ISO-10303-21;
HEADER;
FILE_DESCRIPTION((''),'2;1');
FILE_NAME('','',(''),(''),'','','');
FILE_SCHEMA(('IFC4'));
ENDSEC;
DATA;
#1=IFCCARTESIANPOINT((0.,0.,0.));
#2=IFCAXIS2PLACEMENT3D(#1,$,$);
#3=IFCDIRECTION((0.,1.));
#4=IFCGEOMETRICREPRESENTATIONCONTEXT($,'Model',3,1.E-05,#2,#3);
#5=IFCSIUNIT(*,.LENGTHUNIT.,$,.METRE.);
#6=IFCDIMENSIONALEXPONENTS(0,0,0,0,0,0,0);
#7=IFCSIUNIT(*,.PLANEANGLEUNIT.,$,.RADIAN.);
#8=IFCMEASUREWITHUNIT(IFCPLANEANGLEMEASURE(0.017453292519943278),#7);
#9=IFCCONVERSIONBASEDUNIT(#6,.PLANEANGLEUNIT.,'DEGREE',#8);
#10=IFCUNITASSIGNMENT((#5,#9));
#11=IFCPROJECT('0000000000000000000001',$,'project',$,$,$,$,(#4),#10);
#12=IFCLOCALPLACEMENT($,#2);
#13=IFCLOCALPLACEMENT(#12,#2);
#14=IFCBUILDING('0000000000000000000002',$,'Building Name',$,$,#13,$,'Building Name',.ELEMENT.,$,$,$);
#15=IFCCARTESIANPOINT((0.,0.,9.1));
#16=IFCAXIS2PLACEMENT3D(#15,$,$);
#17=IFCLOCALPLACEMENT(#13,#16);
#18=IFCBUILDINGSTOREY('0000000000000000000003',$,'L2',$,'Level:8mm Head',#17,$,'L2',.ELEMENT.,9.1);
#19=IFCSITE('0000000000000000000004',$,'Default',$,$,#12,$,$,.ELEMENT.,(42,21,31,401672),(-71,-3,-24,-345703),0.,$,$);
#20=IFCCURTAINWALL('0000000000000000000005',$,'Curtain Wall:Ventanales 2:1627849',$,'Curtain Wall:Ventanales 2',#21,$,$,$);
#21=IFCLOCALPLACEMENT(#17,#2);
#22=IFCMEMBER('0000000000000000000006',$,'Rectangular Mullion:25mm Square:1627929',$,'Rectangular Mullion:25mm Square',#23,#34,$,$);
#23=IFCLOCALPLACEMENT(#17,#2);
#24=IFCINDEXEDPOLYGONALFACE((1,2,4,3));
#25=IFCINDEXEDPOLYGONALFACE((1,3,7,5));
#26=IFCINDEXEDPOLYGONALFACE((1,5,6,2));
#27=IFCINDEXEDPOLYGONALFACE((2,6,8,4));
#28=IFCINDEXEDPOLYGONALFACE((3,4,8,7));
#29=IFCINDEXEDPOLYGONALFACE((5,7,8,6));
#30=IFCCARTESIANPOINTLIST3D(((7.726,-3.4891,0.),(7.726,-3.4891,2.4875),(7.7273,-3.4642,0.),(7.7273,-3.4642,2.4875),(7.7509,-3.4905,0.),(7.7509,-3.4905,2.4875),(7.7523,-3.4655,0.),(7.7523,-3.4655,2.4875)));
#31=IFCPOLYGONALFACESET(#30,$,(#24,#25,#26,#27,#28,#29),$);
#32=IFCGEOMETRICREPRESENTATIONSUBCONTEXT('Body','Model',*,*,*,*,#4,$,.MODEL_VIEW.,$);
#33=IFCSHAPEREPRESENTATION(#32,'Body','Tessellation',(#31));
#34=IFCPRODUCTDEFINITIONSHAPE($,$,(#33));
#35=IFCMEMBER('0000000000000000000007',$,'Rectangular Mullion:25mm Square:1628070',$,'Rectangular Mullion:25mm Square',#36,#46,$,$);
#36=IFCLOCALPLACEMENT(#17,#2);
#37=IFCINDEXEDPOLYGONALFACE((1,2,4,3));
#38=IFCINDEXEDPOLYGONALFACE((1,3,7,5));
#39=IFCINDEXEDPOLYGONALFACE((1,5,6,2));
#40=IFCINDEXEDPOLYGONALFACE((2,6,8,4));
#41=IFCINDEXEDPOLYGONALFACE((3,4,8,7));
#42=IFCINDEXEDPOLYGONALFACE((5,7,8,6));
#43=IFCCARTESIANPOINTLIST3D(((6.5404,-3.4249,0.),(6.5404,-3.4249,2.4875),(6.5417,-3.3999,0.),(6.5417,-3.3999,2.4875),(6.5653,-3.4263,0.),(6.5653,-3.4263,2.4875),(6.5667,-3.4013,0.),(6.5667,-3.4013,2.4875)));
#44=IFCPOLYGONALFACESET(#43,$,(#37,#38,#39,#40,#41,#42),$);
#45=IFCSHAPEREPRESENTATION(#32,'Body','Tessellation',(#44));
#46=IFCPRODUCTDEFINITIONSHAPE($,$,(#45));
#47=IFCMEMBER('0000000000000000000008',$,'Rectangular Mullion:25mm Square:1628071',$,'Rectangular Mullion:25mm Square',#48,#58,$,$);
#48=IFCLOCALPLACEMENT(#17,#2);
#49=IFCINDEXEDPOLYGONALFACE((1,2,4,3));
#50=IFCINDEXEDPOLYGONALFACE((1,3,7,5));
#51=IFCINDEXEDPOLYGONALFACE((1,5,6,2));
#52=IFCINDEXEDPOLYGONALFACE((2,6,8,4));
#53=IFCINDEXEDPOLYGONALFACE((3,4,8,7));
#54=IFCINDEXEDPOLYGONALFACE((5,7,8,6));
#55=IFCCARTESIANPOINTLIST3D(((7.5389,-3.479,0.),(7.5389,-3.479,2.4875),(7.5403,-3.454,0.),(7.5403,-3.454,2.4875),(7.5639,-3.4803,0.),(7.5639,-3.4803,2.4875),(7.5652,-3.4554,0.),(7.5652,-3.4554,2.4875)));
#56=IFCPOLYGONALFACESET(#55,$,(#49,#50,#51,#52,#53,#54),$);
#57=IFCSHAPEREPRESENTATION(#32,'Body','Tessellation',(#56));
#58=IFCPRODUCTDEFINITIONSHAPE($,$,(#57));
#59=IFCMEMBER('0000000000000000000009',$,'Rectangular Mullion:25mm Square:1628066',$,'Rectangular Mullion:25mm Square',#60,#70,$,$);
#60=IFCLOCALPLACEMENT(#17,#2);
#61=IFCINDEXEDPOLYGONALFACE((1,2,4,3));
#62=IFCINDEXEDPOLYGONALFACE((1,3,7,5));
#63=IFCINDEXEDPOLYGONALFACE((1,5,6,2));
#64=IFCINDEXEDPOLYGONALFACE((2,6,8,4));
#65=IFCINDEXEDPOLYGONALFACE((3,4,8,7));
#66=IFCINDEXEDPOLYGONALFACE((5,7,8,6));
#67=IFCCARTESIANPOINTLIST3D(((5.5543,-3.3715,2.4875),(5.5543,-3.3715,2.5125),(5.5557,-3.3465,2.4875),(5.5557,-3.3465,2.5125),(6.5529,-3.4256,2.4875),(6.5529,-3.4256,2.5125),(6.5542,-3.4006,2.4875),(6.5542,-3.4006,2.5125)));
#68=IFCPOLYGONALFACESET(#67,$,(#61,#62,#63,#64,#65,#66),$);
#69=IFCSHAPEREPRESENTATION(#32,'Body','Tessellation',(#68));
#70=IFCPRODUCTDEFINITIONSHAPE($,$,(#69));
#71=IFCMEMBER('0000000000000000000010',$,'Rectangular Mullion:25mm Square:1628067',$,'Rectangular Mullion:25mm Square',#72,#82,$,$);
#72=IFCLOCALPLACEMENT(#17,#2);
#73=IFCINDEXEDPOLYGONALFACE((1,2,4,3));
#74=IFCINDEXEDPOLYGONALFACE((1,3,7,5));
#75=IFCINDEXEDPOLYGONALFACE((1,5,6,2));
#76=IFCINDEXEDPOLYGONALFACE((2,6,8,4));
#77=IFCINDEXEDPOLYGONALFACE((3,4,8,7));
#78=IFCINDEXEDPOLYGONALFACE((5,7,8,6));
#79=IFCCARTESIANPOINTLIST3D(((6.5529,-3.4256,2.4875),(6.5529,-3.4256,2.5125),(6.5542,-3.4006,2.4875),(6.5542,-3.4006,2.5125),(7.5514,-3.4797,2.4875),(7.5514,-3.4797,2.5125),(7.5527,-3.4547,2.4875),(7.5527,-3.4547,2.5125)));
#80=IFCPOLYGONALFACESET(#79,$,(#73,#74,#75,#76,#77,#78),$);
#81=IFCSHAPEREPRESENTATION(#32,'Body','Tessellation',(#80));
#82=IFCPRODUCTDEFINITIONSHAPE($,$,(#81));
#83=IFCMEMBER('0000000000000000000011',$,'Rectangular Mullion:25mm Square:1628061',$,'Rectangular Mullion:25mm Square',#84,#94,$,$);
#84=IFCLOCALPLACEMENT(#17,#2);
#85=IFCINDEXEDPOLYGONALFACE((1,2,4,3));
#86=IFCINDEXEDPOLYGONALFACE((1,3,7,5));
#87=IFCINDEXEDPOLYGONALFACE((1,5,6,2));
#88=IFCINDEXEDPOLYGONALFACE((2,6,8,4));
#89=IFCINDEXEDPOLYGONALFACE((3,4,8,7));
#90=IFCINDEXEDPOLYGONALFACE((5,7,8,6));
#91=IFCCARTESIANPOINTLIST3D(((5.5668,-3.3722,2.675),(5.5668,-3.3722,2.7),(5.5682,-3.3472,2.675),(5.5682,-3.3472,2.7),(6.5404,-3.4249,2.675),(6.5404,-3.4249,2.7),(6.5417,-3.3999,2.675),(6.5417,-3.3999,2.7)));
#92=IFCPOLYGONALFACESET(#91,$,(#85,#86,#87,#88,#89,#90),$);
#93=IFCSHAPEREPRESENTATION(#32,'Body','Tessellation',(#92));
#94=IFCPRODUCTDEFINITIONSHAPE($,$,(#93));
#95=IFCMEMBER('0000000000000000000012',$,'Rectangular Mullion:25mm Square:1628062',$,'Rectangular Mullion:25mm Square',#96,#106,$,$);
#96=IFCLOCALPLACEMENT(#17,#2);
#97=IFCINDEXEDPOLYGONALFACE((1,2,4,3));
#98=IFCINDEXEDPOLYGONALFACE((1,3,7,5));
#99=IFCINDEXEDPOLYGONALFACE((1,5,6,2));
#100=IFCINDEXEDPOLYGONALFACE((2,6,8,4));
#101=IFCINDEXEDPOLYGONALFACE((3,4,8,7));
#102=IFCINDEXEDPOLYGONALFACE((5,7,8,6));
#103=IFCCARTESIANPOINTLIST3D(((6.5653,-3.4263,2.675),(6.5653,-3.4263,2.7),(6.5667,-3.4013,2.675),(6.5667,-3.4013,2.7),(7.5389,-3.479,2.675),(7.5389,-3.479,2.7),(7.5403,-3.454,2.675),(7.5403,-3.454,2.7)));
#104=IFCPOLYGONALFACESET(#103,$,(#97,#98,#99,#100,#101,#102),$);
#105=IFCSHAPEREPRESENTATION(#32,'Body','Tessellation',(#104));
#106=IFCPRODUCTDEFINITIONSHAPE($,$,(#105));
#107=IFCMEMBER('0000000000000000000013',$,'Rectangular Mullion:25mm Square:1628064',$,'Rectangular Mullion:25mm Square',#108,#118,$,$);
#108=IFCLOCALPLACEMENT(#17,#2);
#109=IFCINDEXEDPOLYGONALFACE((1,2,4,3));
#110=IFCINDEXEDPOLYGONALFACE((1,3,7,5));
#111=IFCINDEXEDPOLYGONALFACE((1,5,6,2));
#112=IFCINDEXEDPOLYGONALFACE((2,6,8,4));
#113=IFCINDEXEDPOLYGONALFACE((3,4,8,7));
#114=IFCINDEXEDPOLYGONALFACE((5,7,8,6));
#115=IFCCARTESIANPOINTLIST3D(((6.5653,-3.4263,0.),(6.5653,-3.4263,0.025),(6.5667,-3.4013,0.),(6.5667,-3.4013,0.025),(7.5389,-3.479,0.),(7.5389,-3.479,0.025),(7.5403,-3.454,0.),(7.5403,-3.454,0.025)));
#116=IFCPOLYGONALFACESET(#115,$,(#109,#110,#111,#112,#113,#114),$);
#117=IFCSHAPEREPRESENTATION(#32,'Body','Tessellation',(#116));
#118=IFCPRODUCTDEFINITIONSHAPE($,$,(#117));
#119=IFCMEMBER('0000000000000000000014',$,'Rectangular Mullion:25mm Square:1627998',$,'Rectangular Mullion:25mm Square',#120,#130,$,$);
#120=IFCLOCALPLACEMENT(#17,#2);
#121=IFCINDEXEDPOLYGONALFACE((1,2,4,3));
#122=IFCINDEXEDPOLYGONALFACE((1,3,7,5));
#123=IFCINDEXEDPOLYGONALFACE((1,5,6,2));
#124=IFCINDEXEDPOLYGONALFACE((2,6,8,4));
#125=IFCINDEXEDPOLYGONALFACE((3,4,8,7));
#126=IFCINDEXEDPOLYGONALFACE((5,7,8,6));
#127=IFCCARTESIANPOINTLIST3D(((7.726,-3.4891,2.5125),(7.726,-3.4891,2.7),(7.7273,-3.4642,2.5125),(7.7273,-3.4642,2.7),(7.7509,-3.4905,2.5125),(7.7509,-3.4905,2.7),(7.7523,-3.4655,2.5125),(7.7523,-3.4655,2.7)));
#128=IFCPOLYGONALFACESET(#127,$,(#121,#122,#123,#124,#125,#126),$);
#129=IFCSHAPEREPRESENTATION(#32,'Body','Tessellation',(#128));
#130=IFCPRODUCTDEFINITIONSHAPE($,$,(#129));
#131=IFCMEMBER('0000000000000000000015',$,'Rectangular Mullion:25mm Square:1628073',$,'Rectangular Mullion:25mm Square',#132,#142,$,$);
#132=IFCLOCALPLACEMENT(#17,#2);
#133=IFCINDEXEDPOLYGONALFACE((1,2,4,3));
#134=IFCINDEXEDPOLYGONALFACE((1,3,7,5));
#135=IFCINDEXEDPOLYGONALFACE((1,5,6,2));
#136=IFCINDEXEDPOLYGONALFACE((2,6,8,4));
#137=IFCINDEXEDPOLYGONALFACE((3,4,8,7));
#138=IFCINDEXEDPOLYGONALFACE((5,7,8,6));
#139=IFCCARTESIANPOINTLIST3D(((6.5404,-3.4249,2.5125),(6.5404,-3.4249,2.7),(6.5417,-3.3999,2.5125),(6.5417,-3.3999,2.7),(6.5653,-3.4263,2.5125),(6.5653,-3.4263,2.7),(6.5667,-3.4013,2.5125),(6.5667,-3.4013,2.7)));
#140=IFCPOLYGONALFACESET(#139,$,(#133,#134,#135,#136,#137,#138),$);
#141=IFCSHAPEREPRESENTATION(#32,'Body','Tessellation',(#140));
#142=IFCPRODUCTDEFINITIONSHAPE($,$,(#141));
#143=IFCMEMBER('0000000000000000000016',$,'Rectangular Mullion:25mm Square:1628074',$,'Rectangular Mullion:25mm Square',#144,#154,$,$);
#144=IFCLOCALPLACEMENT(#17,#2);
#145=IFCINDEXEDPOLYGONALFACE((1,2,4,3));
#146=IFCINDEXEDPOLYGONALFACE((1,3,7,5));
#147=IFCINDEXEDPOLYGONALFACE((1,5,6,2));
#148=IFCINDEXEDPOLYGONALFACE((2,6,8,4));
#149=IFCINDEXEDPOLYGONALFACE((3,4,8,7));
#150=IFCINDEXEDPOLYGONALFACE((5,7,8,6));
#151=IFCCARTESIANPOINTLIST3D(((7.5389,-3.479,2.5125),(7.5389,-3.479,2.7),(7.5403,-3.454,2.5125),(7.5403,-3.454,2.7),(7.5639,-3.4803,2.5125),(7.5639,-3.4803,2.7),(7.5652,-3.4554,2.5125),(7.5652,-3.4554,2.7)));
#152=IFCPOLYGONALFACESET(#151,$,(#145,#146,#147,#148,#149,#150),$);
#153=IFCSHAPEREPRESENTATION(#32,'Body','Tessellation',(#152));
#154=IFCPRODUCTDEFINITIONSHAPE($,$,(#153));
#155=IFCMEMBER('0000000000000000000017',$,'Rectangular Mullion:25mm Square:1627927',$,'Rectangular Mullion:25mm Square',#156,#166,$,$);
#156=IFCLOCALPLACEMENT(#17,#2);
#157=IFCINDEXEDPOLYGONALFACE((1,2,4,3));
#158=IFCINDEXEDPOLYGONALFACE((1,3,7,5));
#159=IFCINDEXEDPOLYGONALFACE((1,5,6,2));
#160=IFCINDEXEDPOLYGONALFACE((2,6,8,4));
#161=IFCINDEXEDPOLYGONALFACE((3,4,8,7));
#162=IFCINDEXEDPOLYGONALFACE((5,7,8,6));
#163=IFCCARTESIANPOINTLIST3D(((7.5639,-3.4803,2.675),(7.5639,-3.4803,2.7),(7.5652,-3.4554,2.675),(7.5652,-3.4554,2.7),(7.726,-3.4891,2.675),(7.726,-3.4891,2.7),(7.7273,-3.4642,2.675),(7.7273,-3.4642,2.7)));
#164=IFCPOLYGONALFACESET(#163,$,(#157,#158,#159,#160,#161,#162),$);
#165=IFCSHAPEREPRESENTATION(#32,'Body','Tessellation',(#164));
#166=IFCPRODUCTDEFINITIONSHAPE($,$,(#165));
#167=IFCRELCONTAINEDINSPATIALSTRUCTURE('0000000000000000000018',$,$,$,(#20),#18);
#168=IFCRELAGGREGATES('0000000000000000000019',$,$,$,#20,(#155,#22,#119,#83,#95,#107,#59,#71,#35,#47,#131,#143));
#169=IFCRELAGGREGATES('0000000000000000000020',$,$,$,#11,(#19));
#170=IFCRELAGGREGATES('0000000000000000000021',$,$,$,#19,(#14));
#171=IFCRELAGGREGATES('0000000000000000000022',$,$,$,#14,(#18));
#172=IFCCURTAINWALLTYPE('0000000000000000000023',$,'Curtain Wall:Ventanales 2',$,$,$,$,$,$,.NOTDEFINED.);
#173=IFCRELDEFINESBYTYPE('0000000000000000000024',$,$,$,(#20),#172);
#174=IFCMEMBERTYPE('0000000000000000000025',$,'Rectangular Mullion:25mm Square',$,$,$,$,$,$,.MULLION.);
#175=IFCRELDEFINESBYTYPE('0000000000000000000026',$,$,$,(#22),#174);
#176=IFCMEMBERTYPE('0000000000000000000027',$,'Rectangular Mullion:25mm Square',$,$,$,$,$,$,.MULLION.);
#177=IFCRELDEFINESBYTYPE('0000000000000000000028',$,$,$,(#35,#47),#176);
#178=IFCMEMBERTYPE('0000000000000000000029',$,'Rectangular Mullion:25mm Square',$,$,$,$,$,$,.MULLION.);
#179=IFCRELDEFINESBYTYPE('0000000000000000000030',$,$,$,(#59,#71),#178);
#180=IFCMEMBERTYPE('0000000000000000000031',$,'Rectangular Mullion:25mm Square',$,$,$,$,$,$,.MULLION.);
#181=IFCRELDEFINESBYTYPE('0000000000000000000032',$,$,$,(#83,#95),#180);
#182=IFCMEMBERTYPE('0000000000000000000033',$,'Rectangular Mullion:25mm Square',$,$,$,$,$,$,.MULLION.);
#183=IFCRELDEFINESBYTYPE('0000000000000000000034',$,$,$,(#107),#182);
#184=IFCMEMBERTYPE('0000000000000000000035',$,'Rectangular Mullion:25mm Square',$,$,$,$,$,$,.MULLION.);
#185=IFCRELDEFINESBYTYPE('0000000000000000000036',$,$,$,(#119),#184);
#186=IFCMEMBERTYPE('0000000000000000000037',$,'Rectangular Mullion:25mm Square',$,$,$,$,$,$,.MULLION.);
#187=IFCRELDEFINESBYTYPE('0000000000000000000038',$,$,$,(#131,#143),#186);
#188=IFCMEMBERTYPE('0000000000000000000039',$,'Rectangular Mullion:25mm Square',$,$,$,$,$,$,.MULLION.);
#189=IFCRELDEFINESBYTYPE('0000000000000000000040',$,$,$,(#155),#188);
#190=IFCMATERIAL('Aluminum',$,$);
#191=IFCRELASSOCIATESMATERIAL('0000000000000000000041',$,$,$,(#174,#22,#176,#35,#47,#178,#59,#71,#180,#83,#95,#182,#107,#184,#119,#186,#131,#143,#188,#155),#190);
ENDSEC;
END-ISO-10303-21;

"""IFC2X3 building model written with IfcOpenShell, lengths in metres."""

from ifc_helpers import new_model, entity, si_unit, converted_unit, direction, frame, frame_2d, origin, origin_2d_with_axis, place, context, subcontext, project, spatial, rectangle, extrude, source, transform, mapped, material, type_object, type_shapes, element, aggregate, save


model = new_model("IFC2X3")

# Units and contexts
model_context = context("Model", 3, precision=1e-05, world=origin(), true_north=direction((0.0, 1.0)))
body_context = subcontext(model_context, "Body", "Model", "MODEL_VIEW")
ifc_project = project(units=[si_unit("LENGTHUNIT", "METRE"), converted_unit("PLANEANGLEUNIT", "DEGREE", entity("IfcPlaneAngleMeasure", 0.017453292519943278), si_unit("PLANEANGLEUNIT", "RADIAN"), dimensions=[0, 0, 0, 0, 0, 0, 0])], contexts=[model_context])

# Site, building, storey
site_placement = place(None, origin())
site = spatial("IfcSite", under=ifc_project, at=site_placement, Name="Default", CompositionType="ELEMENT", RefLatitude=(42, 21, 31, 401672), RefLongitude=(-71, -3, -24, -345703), RefElevation=0.0)
building_placement = place(site_placement, origin())
building = spatial("IfcBuilding", under=site, at=building_placement, Name="Building Name", LongName="Building Name", CompositionType="ELEMENT")
storey_placement = place(building_placement, frame((0.0, 0.0, 9.1)))
storey = spatial("IfcBuildingStorey", under=building, at=storey_placement, Name="L2", ObjectType="Level:8mm Head", LongName="L2", CompositionType="ELEMENT", Elevation=9.1)

# Curtain wall, members
curtain_wall_type = type_object("IfcCurtainWallType", Name="Curtain Wall:Ventanales 2", PredefinedType="NOTDEFINED")
curtain_wall_placement = place(storey_placement, frame((0.0, 0.0, -9.1)))
curtain_wall = element("IfcCurtainWall", 1, at=curtain_wall_placement, inside=storey, type_object=curtain_wall_type, Name="Curtain Wall:Ventanales 2:1627849", ObjectType="Curtain Wall:Ventanales 2")
ifc_material_1 = material(Name="Aluminum")
member_type_1 = type_object("IfcMemberType", Name="Rectangular Mullion:25mm Square", PredefinedType="MULLION", material=ifc_material_1)
shared_shape_1 = source(origin(), body_context, "Body", "SweptSolid", [
    extrude(rectangle(XDim=0.025, YDim=0.025, at=origin_2d_with_axis()), frame((-0.0125, 0.0, -2.4875), z_axis=(0.0, 0.0, 1.0), x_axis=(-1.0, 0.0, 0.0)), (0.0, 0.0, 1.0), 2.4875),
])
type_shapes(member_type_1, [shared_shape_1])
member_1_placement = place(curtain_wall_placement, frame((7.7516, -3.478, 9.1), z_axis=(0.0, 0.0, -1.0), x_axis=(0.998536, -0.054083, 0.0)))
member_1 = element("IfcMember", 2, at=member_1_placement, type_object=member_type_1, material=ifc_material_1, Name="Rectangular Mullion:25mm Square:1627929", ObjectType="Rectangular Mullion:25mm Square", context=body_context, shape_type="MappedRepresentation", body=[
    mapped(shared_shape_1, transform((0.0, 0.0, 0.0), scale=1.0)),
])
member_type_2 = type_object("IfcMemberType", Name="Rectangular Mullion:25mm Square", PredefinedType="MULLION", material=ifc_material_1)
shared_shape_2 = source(origin(), body_context, "Body", "SweptSolid", [
    extrude(rectangle(XDim=0.025, YDim=0.025, at=origin_2d_with_axis()), frame((0.0, 0.0, -2.4875), z_axis=(0.0, 0.0, 1.0), x_axis=(-1.0, 0.0, 0.0)), (0.0, 0.0, 1.0), 2.4875),
])
type_shapes(member_type_2, [shared_shape_2])
member_2_placement = place(curtain_wall_placement, frame((6.5535, -3.4131, 9.1), z_axis=(0.0, 0.0, -1.0), x_axis=(0.998536, -0.054083, 0.0)))
member_2 = element("IfcMember", 3, at=member_2_placement, type_object=member_type_2, material=ifc_material_1, Name="Rectangular Mullion:25mm Square:1628070", ObjectType="Rectangular Mullion:25mm Square", context=body_context, shape_type="MappedRepresentation", body=[
    mapped(shared_shape_2, transform((0.0, 0.0, 0.0), scale=1.0)),
])
member_3_placement = place(curtain_wall_placement, frame((7.5521, -3.4672, 9.1), z_axis=(0.0, 0.0, -1.0), x_axis=(0.998536, -0.054083, 0.0)))
member_3 = element("IfcMember", 4, at=member_3_placement, type_object=member_type_2, material=ifc_material_1, Name="Rectangular Mullion:25mm Square:1628071", ObjectType="Rectangular Mullion:25mm Square", context=body_context, shape_type="MappedRepresentation", body=[
    mapped(shared_shape_2, transform((0.0, 0.0, 0.0), scale=1.0)),
])
member_type_3 = type_object("IfcMemberType", Name="Rectangular Mullion:25mm Square", PredefinedType="MULLION", material=ifc_material_1)
shared_shape_3 = source(origin(), body_context, "Body", "SweptSolid", [
    extrude(rectangle(XDim=0.025, YDim=0.025, at=frame_2d((0.0, 0.0), x_axis=(1.0, 0.0))), frame((0.0, 0.0, -1.0), z_axis=(0.0, 0.0, 1.0), x_axis=(-1.0, 0.0, 0.0)), (0.0, 0.0, 1.0), 1.0),
])
type_shapes(member_type_3, [shared_shape_3])
member_4_placement = place(curtain_wall_placement, frame((6.5535, -3.4131, 11.6), z_axis=(0.998536, -0.054083, 0.0), x_axis=(0.0, 0.0, 1.0)))
member_4 = element("IfcMember", 5, at=member_4_placement, type_object=member_type_3, material=ifc_material_1, Name="Rectangular Mullion:25mm Square:1628066", ObjectType="Rectangular Mullion:25mm Square", context=body_context, shape_type="MappedRepresentation", body=[
    mapped(shared_shape_3, transform((0.0, 0.0, 0.0), scale=1.0)),
])
member_5_placement = place(curtain_wall_placement, frame((7.5521, -3.4672, 11.6), z_axis=(0.998536, -0.054083, 0.0), x_axis=(0.0, 0.0, 1.0)))
member_5 = element("IfcMember", 6, at=member_5_placement, type_object=member_type_3, material=ifc_material_1, Name="Rectangular Mullion:25mm Square:1628067", ObjectType="Rectangular Mullion:25mm Square", context=body_context, shape_type="MappedRepresentation", body=[
    mapped(shared_shape_3, transform((0.0, 0.0, 0.0), scale=1.0)),
])
member_type_4 = type_object("IfcMemberType", Name="Rectangular Mullion:25mm Square", PredefinedType="MULLION", material=ifc_material_1)
shared_shape_4 = source(origin(), body_context, "Body", "SweptSolid", [
    extrude(rectangle(XDim=0.025, YDim=0.025, at=origin_2d_with_axis()), frame((-0.0125, 0.0, -0.975), z_axis=(0.0, 0.0, 1.0), x_axis=(-1.0, 0.0, 0.0)), (0.0, 0.0, 1.0), 0.975),
])
type_shapes(member_type_4, [shared_shape_4])
member_6_placement = place(curtain_wall_placement, frame((6.5411, -3.4124, 11.8), z_axis=(0.998536, -0.054083, 0.0), x_axis=(0.0, 0.0, 1.0)))
member_6 = element("IfcMember", 7, at=member_6_placement, type_object=member_type_4, material=ifc_material_1, Name="Rectangular Mullion:25mm Square:1628061", ObjectType="Rectangular Mullion:25mm Square", context=body_context, shape_type="MappedRepresentation", body=[
    mapped(shared_shape_4, transform((0.0, 0.0, 0.0), scale=1.0)),
])
member_7_placement = place(curtain_wall_placement, frame((7.5396, -3.4665, 11.8), z_axis=(0.998536, -0.054083, 0.0), x_axis=(0.0, 0.0, 1.0)))
member_7 = element("IfcMember", 8, at=member_7_placement, type_object=member_type_4, material=ifc_material_1, Name="Rectangular Mullion:25mm Square:1628062", ObjectType="Rectangular Mullion:25mm Square", context=body_context, shape_type="MappedRepresentation", body=[
    mapped(shared_shape_4, transform((0.0, 0.0, 0.0), scale=1.0)),
])
member_type_5 = type_object("IfcMemberType", Name="Rectangular Mullion:25mm Square", PredefinedType="MULLION", material=ifc_material_1)
shared_shape_5 = source(origin(), body_context, "Body", "SweptSolid", [
    extrude(rectangle(XDim=0.025, YDim=0.025, at=origin_2d_with_axis()), frame((-0.0125, 0.0, -0.975), z_axis=(0.0, 0.0, 1.0), x_axis=(-1.0, 0.0, 0.0)), (0.0, 0.0, 1.0), 0.975),
])
type_shapes(member_type_5, [shared_shape_5])
member_8_placement = place(curtain_wall_placement, frame((6.566, -3.4138, 9.1), z_axis=(-0.998536, 0.054083, 0.0), x_axis=(0.0, 0.0, -1.0)))
member_8 = element("IfcMember", 9, at=member_8_placement, type_object=member_type_5, material=ifc_material_1, Name="Rectangular Mullion:25mm Square:1628064", ObjectType="Rectangular Mullion:25mm Square", context=body_context, shape_type="MappedRepresentation", body=[
    mapped(shared_shape_5, transform((0.0, 0.0, 0.0), scale=1.0)),
])
member_type_6 = type_object("IfcMemberType", Name="Rectangular Mullion:25mm Square", PredefinedType="MULLION", material=ifc_material_1)
shared_shape_6 = source(origin(), body_context, "Body", "SweptSolid", [
    extrude(rectangle(XDim=0.025, YDim=0.025, at=origin_2d_with_axis()), frame((-0.0125, 0.0, -0.1875), z_axis=(0.0, 0.0, 1.0), x_axis=(-1.0, 0.0, 0.0)), (0.0, 0.0, 1.0), 0.1875),
])
type_shapes(member_type_6, [shared_shape_6])
member_9_placement = place(curtain_wall_placement, frame((7.7516, -3.478, 11.6125), z_axis=(0.0, 0.0, -1.0), x_axis=(0.998536, -0.054083, 0.0)))
member_9 = element("IfcMember", 10, at=member_9_placement, type_object=member_type_6, material=ifc_material_1, Name="Rectangular Mullion:25mm Square:1627998", ObjectType="Rectangular Mullion:25mm Square", context=body_context, shape_type="MappedRepresentation", body=[
    mapped(shared_shape_6, transform((0.0, 0.0, 0.0), scale=1.0)),
])
member_type_7 = type_object("IfcMemberType", Name="Rectangular Mullion:25mm Square", PredefinedType="MULLION", material=ifc_material_1)
shared_shape_7 = source(origin(), body_context, "Body", "SweptSolid", [
    extrude(rectangle(XDim=0.025, YDim=0.025, at=frame_2d((0.0, 0.0), x_axis=(1.0, 0.0))), frame((0.0, 0.0, -0.1875), z_axis=(0.0, 0.0, 1.0), x_axis=(-1.0, 0.0, 0.0)), (0.0, 0.0, 1.0), 0.1875),
])
type_shapes(member_type_7, [shared_shape_7])
member_10_placement = place(curtain_wall_placement, frame((6.5535, -3.4131, 11.6125), z_axis=(0.0, 0.0, -1.0), x_axis=(0.998536, -0.054083, 0.0)))
member_10 = element("IfcMember", 11, at=member_10_placement, type_object=member_type_7, material=ifc_material_1, Name="Rectangular Mullion:25mm Square:1628073", ObjectType="Rectangular Mullion:25mm Square", context=body_context, shape_type="MappedRepresentation", body=[
    mapped(shared_shape_7, transform((0.0, 0.0, 0.0), scale=1.0)),
])
member_11_placement = place(curtain_wall_placement, frame((7.5521, -3.4672, 11.6125), z_axis=(0.0, 0.0, -1.0), x_axis=(0.998536, -0.054083, 0.0)))
member_11 = element("IfcMember", 12, at=member_11_placement, type_object=member_type_7, material=ifc_material_1, Name="Rectangular Mullion:25mm Square:1628074", ObjectType="Rectangular Mullion:25mm Square", context=body_context, shape_type="MappedRepresentation", body=[
    mapped(shared_shape_7, transform((0.0, 0.0, 0.0), scale=1.0)),
])
member_type_8 = type_object("IfcMemberType", Name="Rectangular Mullion:25mm Square", PredefinedType="MULLION", material=ifc_material_1)
shared_shape_8 = source(origin(), body_context, "Body", "SweptSolid", [
    extrude(rectangle(XDim=0.025, YDim=0.025, at=origin_2d_with_axis()), frame((-0.0125, 0.0, -0.1623), z_axis=(0.0, 0.0, 1.0), x_axis=(-1.0, 0.0, 0.0)), (0.0, 0.0, 1.0), 0.1623),
])
type_shapes(member_type_8, [shared_shape_8])
member_12_placement = place(curtain_wall_placement, frame((7.7266, -3.4766, 11.8), z_axis=(0.998536, -0.054083, 0.0), x_axis=(0.0, 0.0, 1.0)))
member_12 = element("IfcMember", 13, at=member_12_placement, type_object=member_type_8, material=ifc_material_1, Name="Rectangular Mullion:25mm Square:1627927", ObjectType="Rectangular Mullion:25mm Square", context=body_context, shape_type="MappedRepresentation", body=[
    mapped(shared_shape_8, transform((0.0, 0.0, 0.0), scale=1.0)),
])
aggregate(curtain_wall, [member_12, member_1, member_9, member_6, member_7, member_8, member_4, member_5, member_2, member_3, member_10, member_11])

save(model, "model.ifc")
